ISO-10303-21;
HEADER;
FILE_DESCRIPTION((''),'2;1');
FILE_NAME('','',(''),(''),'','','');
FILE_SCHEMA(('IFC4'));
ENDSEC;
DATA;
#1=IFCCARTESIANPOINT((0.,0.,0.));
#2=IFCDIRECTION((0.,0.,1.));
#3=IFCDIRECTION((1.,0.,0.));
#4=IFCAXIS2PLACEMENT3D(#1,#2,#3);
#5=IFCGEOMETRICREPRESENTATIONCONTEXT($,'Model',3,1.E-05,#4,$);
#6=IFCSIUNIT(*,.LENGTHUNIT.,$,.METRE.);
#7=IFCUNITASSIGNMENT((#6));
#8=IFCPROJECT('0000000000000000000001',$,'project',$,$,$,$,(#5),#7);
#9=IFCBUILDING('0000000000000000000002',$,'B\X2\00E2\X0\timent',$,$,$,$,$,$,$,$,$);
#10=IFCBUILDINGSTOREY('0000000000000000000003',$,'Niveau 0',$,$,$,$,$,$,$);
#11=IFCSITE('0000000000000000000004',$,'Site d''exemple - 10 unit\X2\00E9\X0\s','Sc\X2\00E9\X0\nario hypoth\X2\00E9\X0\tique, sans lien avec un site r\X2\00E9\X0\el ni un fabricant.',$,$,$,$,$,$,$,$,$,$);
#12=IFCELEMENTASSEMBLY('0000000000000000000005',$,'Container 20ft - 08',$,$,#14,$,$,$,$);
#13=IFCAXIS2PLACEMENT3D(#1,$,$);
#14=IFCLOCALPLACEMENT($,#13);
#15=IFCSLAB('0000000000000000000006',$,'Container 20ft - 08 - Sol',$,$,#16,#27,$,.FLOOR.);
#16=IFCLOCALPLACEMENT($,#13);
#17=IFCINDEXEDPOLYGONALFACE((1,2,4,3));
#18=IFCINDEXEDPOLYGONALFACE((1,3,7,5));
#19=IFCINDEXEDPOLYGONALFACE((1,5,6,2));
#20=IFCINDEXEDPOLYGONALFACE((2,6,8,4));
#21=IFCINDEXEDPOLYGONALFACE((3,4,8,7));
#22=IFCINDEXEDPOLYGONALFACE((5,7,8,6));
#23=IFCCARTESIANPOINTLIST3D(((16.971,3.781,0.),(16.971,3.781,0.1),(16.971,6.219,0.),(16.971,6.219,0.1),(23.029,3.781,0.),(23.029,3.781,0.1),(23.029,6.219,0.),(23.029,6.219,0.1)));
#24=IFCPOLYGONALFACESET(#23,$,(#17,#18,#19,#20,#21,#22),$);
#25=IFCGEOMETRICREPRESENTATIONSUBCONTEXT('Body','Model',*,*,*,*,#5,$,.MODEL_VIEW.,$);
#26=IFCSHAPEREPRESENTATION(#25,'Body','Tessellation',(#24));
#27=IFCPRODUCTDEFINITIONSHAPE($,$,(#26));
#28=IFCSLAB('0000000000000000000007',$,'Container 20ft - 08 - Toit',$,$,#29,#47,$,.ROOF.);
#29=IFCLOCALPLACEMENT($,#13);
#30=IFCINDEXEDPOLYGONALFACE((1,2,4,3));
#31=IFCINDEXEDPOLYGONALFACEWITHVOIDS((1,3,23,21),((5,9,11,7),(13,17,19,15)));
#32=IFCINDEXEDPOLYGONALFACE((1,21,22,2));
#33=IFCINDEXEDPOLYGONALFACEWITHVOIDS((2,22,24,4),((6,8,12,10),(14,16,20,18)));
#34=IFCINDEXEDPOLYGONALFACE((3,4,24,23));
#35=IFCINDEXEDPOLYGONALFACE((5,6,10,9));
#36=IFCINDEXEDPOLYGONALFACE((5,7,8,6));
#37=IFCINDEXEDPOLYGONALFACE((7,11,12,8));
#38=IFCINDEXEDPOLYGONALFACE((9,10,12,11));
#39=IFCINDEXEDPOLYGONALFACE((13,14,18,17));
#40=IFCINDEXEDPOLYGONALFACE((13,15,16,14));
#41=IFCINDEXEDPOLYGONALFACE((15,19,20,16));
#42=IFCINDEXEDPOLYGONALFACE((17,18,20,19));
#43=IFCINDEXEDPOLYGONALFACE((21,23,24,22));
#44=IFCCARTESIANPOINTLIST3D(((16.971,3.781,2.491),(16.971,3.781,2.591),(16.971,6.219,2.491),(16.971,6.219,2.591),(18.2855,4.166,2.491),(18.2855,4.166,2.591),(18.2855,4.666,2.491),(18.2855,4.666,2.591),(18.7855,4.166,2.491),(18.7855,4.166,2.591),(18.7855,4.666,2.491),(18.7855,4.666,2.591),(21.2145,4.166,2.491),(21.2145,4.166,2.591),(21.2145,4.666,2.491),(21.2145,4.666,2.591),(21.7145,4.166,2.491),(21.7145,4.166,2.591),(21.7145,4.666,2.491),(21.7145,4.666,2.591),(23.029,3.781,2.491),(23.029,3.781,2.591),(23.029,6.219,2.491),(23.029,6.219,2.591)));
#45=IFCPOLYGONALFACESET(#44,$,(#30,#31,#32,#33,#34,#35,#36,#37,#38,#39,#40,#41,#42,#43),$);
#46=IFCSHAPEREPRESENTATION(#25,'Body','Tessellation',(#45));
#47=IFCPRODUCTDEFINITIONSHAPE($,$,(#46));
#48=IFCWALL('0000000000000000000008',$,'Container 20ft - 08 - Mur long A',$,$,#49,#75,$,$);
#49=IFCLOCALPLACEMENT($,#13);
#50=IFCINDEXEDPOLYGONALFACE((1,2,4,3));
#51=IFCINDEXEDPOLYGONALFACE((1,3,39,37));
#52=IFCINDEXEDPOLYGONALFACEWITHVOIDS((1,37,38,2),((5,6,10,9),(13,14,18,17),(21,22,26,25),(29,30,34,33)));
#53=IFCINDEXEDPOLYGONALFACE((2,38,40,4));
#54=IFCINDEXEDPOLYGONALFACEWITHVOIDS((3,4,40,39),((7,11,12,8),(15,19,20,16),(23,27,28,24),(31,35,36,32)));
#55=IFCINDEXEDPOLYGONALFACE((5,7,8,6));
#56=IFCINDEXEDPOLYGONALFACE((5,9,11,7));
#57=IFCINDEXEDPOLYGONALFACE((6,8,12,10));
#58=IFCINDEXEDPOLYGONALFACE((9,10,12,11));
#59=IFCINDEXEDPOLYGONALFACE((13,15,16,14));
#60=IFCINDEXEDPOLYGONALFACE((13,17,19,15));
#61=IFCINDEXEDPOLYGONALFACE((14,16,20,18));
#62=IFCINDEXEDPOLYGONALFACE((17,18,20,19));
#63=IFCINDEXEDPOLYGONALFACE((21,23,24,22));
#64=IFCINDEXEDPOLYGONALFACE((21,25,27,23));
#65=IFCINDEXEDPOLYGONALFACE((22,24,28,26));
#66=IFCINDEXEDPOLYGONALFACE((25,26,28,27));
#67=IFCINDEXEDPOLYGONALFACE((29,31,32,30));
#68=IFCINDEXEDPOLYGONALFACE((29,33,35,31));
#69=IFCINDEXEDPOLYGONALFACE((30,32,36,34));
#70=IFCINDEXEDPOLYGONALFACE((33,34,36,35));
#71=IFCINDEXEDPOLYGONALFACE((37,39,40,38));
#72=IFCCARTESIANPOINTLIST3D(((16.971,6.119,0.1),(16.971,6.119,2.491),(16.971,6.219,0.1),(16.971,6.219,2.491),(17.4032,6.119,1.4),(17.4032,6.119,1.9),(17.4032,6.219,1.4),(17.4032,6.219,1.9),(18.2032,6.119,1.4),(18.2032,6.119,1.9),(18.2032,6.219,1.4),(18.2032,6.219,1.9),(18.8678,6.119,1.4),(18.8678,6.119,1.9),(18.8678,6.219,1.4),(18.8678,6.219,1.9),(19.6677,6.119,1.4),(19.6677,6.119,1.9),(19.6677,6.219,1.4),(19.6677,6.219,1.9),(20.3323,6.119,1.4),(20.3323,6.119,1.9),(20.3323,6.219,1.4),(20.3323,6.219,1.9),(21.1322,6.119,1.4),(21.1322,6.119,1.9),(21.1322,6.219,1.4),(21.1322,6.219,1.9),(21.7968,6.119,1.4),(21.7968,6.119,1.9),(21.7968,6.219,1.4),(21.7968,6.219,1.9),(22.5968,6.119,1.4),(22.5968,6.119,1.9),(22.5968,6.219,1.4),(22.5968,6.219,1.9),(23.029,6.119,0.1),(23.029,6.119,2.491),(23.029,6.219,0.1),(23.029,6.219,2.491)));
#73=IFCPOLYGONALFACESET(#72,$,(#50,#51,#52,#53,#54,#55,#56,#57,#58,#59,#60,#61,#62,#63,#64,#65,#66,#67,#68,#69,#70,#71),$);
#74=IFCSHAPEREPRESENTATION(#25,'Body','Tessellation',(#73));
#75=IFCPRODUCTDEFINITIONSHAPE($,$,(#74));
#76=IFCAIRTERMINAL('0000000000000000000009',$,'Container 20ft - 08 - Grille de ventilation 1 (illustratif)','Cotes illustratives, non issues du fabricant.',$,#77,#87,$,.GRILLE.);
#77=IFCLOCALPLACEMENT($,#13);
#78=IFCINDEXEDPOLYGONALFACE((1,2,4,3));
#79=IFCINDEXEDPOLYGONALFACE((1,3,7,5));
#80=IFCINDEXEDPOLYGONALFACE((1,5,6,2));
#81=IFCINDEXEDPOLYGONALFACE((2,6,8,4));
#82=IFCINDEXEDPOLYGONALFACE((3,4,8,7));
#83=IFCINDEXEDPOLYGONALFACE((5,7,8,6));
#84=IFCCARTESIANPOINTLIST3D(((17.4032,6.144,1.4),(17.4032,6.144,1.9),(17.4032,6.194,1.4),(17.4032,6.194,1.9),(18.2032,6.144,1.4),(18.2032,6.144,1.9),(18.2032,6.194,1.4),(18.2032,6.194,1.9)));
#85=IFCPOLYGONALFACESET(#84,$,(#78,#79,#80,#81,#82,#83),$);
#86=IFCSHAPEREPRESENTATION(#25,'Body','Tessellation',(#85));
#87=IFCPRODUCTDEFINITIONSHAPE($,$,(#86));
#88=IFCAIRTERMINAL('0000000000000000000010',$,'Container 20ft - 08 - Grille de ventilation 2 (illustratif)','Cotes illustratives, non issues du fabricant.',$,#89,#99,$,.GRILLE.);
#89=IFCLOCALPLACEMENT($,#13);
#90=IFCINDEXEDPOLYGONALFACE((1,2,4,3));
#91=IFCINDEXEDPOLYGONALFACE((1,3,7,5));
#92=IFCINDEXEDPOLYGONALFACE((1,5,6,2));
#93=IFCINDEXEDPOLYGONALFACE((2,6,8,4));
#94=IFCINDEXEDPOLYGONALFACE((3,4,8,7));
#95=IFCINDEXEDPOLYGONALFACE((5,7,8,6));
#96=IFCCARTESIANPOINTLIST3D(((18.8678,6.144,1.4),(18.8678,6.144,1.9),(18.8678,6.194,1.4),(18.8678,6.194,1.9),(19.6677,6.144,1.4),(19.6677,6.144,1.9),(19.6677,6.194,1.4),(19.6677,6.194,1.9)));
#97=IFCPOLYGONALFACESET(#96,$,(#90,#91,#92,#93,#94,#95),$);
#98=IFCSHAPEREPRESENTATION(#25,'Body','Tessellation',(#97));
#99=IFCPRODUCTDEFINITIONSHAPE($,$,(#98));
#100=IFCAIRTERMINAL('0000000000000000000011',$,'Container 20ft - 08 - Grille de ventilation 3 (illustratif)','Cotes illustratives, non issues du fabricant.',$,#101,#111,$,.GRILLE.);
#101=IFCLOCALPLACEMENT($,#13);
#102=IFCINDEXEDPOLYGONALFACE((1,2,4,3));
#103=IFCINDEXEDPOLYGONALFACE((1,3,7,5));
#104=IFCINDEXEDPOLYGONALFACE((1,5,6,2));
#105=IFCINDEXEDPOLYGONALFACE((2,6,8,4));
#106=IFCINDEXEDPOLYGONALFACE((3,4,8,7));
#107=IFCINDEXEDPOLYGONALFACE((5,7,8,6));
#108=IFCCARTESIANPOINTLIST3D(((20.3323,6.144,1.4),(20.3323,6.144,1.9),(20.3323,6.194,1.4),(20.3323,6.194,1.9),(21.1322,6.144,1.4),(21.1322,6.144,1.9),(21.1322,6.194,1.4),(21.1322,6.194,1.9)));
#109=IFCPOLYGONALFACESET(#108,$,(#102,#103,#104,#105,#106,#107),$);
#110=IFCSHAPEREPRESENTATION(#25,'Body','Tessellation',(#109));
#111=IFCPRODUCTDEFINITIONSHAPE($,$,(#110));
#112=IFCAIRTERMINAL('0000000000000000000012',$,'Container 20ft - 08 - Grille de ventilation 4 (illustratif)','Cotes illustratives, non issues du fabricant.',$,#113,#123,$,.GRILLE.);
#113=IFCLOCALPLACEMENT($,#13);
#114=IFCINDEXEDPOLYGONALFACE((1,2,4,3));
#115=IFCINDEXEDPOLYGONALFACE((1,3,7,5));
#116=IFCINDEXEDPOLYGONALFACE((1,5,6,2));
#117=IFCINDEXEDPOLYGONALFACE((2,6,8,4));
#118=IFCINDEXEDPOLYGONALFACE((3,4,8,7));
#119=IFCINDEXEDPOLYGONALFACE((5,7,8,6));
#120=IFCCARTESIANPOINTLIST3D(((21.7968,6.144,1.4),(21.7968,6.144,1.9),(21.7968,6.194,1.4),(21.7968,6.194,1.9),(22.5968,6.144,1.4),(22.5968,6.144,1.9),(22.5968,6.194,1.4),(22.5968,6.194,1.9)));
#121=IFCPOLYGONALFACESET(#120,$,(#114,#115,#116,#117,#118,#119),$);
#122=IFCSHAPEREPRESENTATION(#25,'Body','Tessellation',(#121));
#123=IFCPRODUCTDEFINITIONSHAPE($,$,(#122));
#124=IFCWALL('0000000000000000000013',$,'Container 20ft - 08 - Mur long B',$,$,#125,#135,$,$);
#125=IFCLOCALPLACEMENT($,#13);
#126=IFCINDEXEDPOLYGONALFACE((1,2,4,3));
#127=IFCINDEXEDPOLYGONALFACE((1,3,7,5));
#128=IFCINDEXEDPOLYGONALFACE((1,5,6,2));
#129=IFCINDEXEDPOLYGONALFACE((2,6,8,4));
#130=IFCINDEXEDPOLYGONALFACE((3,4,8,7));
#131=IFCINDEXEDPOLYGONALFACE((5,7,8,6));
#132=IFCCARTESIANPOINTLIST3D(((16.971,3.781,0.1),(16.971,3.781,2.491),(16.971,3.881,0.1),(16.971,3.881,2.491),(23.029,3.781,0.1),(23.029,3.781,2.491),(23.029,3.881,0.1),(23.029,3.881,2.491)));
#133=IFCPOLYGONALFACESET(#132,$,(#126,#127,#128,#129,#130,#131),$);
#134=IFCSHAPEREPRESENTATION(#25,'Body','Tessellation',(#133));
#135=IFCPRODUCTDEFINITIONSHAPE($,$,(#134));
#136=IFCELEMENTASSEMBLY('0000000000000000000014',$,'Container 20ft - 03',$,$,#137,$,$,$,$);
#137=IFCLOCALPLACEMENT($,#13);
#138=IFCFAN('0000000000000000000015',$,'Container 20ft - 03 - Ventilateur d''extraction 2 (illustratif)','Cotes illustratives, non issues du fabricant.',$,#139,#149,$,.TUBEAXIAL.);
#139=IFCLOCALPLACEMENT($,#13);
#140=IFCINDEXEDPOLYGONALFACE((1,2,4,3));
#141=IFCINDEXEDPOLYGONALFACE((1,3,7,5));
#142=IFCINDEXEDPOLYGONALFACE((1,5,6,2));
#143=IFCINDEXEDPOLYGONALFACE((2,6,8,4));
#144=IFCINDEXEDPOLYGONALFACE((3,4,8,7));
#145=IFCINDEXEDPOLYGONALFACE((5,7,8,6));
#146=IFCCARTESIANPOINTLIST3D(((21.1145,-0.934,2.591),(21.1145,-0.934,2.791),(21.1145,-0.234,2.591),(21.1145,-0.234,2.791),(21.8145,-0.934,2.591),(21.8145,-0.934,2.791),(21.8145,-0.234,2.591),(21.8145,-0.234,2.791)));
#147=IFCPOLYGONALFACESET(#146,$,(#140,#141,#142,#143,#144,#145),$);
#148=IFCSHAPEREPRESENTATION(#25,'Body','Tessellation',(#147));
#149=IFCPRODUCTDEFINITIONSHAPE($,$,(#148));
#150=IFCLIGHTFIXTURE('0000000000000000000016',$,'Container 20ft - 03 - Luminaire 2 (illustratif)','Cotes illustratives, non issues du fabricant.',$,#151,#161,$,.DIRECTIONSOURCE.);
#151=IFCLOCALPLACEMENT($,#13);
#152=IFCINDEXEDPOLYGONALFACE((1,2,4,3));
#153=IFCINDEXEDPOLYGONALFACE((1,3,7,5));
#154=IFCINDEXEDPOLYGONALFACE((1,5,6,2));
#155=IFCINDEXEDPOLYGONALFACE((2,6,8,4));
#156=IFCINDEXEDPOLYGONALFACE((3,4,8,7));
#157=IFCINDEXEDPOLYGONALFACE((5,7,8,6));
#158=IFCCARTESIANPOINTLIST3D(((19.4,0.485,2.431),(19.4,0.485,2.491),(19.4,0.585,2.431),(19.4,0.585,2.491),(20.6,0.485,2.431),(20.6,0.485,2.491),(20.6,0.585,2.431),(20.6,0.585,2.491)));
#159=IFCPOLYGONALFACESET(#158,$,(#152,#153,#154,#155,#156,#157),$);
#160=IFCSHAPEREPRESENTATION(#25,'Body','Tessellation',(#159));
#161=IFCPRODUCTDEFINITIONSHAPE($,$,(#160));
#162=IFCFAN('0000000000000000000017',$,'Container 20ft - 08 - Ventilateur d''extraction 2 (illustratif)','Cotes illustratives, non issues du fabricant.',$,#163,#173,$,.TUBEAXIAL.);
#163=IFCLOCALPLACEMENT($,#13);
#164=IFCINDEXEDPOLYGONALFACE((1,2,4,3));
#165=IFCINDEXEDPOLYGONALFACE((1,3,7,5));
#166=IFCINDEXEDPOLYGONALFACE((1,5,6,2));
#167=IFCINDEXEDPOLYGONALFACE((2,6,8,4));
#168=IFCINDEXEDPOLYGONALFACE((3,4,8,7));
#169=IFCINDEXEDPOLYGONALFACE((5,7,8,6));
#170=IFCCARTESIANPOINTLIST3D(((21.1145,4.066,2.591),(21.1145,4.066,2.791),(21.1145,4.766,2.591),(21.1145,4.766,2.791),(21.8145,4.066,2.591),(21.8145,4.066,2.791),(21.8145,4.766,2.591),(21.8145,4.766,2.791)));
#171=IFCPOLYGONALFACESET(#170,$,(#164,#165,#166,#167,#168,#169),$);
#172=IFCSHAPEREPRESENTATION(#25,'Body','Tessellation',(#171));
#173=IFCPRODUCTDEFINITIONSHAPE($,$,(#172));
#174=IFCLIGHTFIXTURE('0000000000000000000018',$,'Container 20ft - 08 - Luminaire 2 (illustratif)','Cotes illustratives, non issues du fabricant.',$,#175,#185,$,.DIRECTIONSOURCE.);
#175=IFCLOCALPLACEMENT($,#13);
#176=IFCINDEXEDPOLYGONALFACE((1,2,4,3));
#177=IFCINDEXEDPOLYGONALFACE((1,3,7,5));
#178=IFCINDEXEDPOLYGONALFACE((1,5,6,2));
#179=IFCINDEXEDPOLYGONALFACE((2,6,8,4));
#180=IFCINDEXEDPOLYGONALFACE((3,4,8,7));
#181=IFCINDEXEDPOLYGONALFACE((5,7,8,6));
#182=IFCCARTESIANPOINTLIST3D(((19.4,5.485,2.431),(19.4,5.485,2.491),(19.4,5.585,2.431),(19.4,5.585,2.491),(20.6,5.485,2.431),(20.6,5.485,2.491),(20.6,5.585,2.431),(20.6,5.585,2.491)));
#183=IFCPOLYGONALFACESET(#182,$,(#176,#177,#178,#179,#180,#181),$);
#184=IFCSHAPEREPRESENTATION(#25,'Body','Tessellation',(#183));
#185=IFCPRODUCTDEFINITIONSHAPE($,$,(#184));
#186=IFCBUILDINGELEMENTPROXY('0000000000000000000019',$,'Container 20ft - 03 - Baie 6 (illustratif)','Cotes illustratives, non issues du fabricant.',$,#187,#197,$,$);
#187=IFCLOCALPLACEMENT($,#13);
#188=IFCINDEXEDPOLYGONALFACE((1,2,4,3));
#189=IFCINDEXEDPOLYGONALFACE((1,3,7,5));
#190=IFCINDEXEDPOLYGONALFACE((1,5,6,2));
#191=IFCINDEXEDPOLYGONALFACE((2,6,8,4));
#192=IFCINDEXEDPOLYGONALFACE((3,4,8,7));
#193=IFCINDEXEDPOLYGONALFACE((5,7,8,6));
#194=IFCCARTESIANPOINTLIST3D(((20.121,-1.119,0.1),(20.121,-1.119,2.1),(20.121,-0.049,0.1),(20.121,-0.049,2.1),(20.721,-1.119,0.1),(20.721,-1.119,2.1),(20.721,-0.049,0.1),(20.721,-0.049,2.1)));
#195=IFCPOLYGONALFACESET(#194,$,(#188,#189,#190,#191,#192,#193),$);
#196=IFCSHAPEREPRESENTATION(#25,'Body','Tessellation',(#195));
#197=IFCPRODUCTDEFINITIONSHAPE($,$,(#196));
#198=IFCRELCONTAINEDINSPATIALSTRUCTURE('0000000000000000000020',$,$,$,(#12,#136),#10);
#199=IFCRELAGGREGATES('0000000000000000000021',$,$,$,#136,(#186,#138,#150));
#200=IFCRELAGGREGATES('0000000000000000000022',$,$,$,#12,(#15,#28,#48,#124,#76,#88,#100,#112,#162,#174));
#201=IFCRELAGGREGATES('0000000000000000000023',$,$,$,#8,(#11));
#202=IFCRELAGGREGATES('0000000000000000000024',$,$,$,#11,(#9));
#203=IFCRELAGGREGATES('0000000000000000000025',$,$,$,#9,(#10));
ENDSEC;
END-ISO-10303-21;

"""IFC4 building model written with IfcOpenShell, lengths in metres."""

from ifc_helpers import new_model, si_unit, frame, origin_with_axes, place, context, subcontext, project, spatial, rectangle, extrude, element, fill, aggregate, save


model = new_model("IFC4")

# Units and contexts
model_context = context("Model", 3, precision=1e-05, world=origin_with_axes())
body_context = subcontext(model_context, "Body", "Model", "MODEL_VIEW")
ifc_project = project(units=[si_unit("LENGTHUNIT", "METRE")], contexts=[model_context])

# Site, building, storey
site = spatial("IfcSite", under=ifc_project, Name="Site d'exemple - 10 unités", Description="Scénario hypothétique, sans lien avec un site réel ni un fabricant.")
building = spatial("IfcBuilding", under=site, Name="Bâtiment")
storey = spatial("IfcBuildingStorey", under=building, Name="Niveau 0")

# Element assembly, slabs, openings, walls, air terminals
assembly_1 = element("IfcElementAssembly", 1, inside=storey, Name="Container 20ft - 08")
slab_1_placement = place(None, frame((20.0, 5.0, 0.0), z_axis=(0.0, 0.0, 1.0), x_axis=(1.0, 0.0, 0.0)))
slab_1 = element("IfcSlab", 2, at=slab_1_placement, Name="Container 20ft - 08 - Sol", PredefinedType="FLOOR", context=body_context, shape_type="SweptSolid", body=[
    extrude(rectangle(XDim=6.058, YDim=2.438), origin_with_axes(), (0.0, 0.0, 1.0), 0.1),
])
slab_2_placement = place(None, frame((20.0, 5.0, 2.491), z_axis=(0.0, 0.0, 1.0), x_axis=(1.0, 0.0, 0.0)))
slab_2 = element("IfcSlab", 3, at=slab_2_placement, Name="Container 20ft - 08 - Toit", PredefinedType="ROOF", context=body_context, shape_type="SweptSolid", body=[
    extrude(rectangle(XDim=6.058, YDim=2.438), origin_with_axes(), (0.0, 0.0, 1.0), 0.1),
])
opening_1_placement = place(None, frame((18.5355, 4.416, 2.441), z_axis=(0.0, 0.0, 1.0), x_axis=(1.0, 0.0, 0.0)))
element("IfcOpeningElement", 4, at=opening_1_placement, cuts=slab_2, PredefinedType="OPENING", context=body_context, shape_type="SweptSolid", body=[
    extrude(rectangle(XDim=0.5, YDim=0.5), origin_with_axes(), (0.0, 0.0, 1.0), 0.2),
])
opening_2_placement = place(None, frame((21.4645, 4.416, 2.441), z_axis=(0.0, 0.0, 1.0), x_axis=(1.0, 0.0, 0.0)))
element("IfcOpeningElement", 5, at=opening_2_placement, cuts=slab_2, PredefinedType="OPENING", context=body_context, shape_type="SweptSolid", body=[
    extrude(rectangle(XDim=0.5, YDim=0.5), origin_with_axes(), (0.0, 0.0, 1.0), 0.2),
])
wall_1_placement = place(None, frame((20.0, 6.169, 0.1), z_axis=(0.0, 0.0, 1.0), x_axis=(1.0, 0.0, 0.0)))
wall_1 = element("IfcWall", 6, at=wall_1_placement, Name="Container 20ft - 08 - Mur long A", context=body_context, shape_type="SweptSolid", body=[
    extrude(rectangle(XDim=6.058, YDim=0.1), origin_with_axes(), (0.0, 0.0, 1.0), 2.391),
])
opening_3_placement = place(None, frame((17.8032, 6.169, 1.4), z_axis=(0.0, 0.0, 1.0), x_axis=(1.0, 0.0, 0.0)))
opening_3 = element("IfcOpeningElement", 7, at=opening_3_placement, cuts=wall_1, PredefinedType="OPENING", context=body_context, shape_type="SweptSolid", body=[
    extrude(rectangle(XDim=0.8, YDim=0.2), origin_with_axes(), (0.0, 0.0, 1.0), 0.5),
])
opening_4_placement = place(None, frame((19.2677, 6.169, 1.4), z_axis=(0.0, 0.0, 1.0), x_axis=(1.0, 0.0, 0.0)))
opening_4 = element("IfcOpeningElement", 8, at=opening_4_placement, cuts=wall_1, PredefinedType="OPENING", context=body_context, shape_type="SweptSolid", body=[
    extrude(rectangle(XDim=0.8, YDim=0.2), origin_with_axes(), (0.0, 0.0, 1.0), 0.5),
])
opening_5_placement = place(None, frame((20.7323, 6.169, 1.4), z_axis=(0.0, 0.0, 1.0), x_axis=(1.0, 0.0, 0.0)))
opening_5 = element("IfcOpeningElement", 9, at=opening_5_placement, cuts=wall_1, PredefinedType="OPENING", context=body_context, shape_type="SweptSolid", body=[
    extrude(rectangle(XDim=0.8, YDim=0.2), origin_with_axes(), (0.0, 0.0, 1.0), 0.5),
])
opening_6_placement = place(None, frame((22.1968, 6.169, 1.4), z_axis=(0.0, 0.0, 1.0), x_axis=(1.0, 0.0, 0.0)))
opening_6 = element("IfcOpeningElement", 10, at=opening_6_placement, cuts=wall_1, PredefinedType="OPENING", context=body_context, shape_type="SweptSolid", body=[
    extrude(rectangle(XDim=0.8, YDim=0.2), origin_with_axes(), (0.0, 0.0, 1.0), 0.5),
])
air_terminal_1_placement = place(None, frame((17.8032, 6.169, 1.4), z_axis=(0.0, 0.0, 1.0), x_axis=(1.0, 0.0, 0.0)))
air_terminal_1 = element("IfcAirTerminal", 11, at=air_terminal_1_placement, Name="Container 20ft - 08 - Grille de ventilation 1 (illustratif)", Description="Cotes illustratives, non issues du fabricant.", PredefinedType="GRILLE", context=body_context, shape_type="SweptSolid", body=[
    extrude(rectangle(XDim=0.8, YDim=0.05), origin_with_axes(), (0.0, 0.0, 1.0), 0.5),
])
fill(opening_3, air_terminal_1)
air_terminal_2_placement = place(None, frame((19.2677, 6.169, 1.4), z_axis=(0.0, 0.0, 1.0), x_axis=(1.0, 0.0, 0.0)))
air_terminal_2 = element("IfcAirTerminal", 12, at=air_terminal_2_placement, Name="Container 20ft - 08 - Grille de ventilation 2 (illustratif)", Description="Cotes illustratives, non issues du fabricant.", PredefinedType="GRILLE", context=body_context, shape_type="SweptSolid", body=[
    extrude(rectangle(XDim=0.8, YDim=0.05), origin_with_axes(), (0.0, 0.0, 1.0), 0.5),
])
fill(opening_4, air_terminal_2)
air_terminal_3_placement = place(None, frame((20.7323, 6.169, 1.4), z_axis=(0.0, 0.0, 1.0), x_axis=(1.0, 0.0, 0.0)))
air_terminal_3 = element("IfcAirTerminal", 13, at=air_terminal_3_placement, Name="Container 20ft - 08 - Grille de ventilation 3 (illustratif)", Description="Cotes illustratives, non issues du fabricant.", PredefinedType="GRILLE", context=body_context, shape_type="SweptSolid", body=[
    extrude(rectangle(XDim=0.8, YDim=0.05), origin_with_axes(), (0.0, 0.0, 1.0), 0.5),
])
fill(opening_5, air_terminal_3)
air_terminal_4_placement = place(None, frame((22.1968, 6.169, 1.4), z_axis=(0.0, 0.0, 1.0), x_axis=(1.0, 0.0, 0.0)))
air_terminal_4 = element("IfcAirTerminal", 14, at=air_terminal_4_placement, Name="Container 20ft - 08 - Grille de ventilation 4 (illustratif)", Description="Cotes illustratives, non issues du fabricant.", PredefinedType="GRILLE", context=body_context, shape_type="SweptSolid", body=[
    extrude(rectangle(XDim=0.8, YDim=0.05), origin_with_axes(), (0.0, 0.0, 1.0), 0.5),
])
fill(opening_6, air_terminal_4)
wall_2_placement = place(None, frame((20.0, 3.831, 0.1), z_axis=(0.0, 0.0, 1.0), x_axis=(1.0, 0.0, 0.0)))
wall_2 = element("IfcWall", 15, at=wall_2_placement, Name="Container 20ft - 08 - Mur long B", context=body_context, shape_type="SweptSolid", body=[
    extrude(rectangle(XDim=6.058, YDim=0.1), origin_with_axes(), (0.0, 0.0, 1.0), 2.391),
])

# Element assembly, fan, light fixture
assembly_2 = element("IfcElementAssembly", 16, inside=storey, Name="Container 20ft - 03")
fan_1_placement = place(None, frame((21.4645, -0.584, 2.591), z_axis=(0.0, 0.0, 1.0), x_axis=(1.0, 0.0, 0.0)))
fan_1 = element("IfcFan", 17, at=fan_1_placement, Name="Container 20ft - 03 - Ventilateur d'extraction 2 (illustratif)", Description="Cotes illustratives, non issues du fabricant.", PredefinedType="TUBEAXIAL", context=body_context, shape_type="SweptSolid", body=[
    extrude(rectangle(XDim=0.7, YDim=0.7), origin_with_axes(), (0.0, 0.0, 1.0), 0.2),
])
light_fixture_1_placement = place(None, frame((20.0, 0.535, 2.431), z_axis=(0.0, 0.0, 1.0), x_axis=(1.0, 0.0, 0.0)))
light_fixture_1 = element("IfcLightFixture", 18, at=light_fixture_1_placement, Name="Container 20ft - 03 - Luminaire 2 (illustratif)", Description="Cotes illustratives, non issues du fabricant.", PredefinedType="DIRECTIONSOURCE", context=body_context, shape_type="SweptSolid", body=[
    extrude(rectangle(XDim=1.2, YDim=0.1), origin_with_axes(), (0.0, 0.0, 1.0), 0.06),
])

# Fan
fan_2_placement = place(None, frame((21.4645, 4.416, 2.591), z_axis=(0.0, 0.0, 1.0), x_axis=(1.0, 0.0, 0.0)))
fan_2 = element("IfcFan", 19, at=fan_2_placement, Name="Container 20ft - 08 - Ventilateur d'extraction 2 (illustratif)", Description="Cotes illustratives, non issues du fabricant.", PredefinedType="TUBEAXIAL", context=body_context, shape_type="SweptSolid", body=[
    extrude(rectangle(XDim=0.7, YDim=0.7), origin_with_axes(), (0.0, 0.0, 1.0), 0.2),
])

# Light fixture
light_fixture_2_placement = place(None, frame((20.0, 5.535, 2.431), z_axis=(0.0, 0.0, 1.0), x_axis=(1.0, 0.0, 0.0)))
light_fixture_2 = element("IfcLightFixture", 20, at=light_fixture_2_placement, Name="Container 20ft - 08 - Luminaire 2 (illustratif)", Description="Cotes illustratives, non issues du fabricant.", PredefinedType="DIRECTIONSOURCE", context=body_context, shape_type="SweptSolid", body=[
    extrude(rectangle(XDim=1.2, YDim=0.1), origin_with_axes(), (0.0, 0.0, 1.0), 0.06),
])

# Building element proxy
proxy_1_placement = place(None, frame((20.421, -0.584, 0.1), z_axis=(0.0, 0.0, 1.0), x_axis=(1.0, 0.0, 0.0)))
proxy_1 = element("IfcBuildingElementProxy", 21, at=proxy_1_placement, Name="Container 20ft - 03 - Baie 6 (illustratif)", Description="Cotes illustratives, non issues du fabricant.", context=body_context, shape_type="SweptSolid", body=[
    extrude(rectangle(XDim=0.6, YDim=1.07), origin_with_axes(), (0.0, 0.0, 1.0), 2.0),
])
aggregate(assembly_2, [proxy_1, fan_1, light_fixture_1])
aggregate(assembly_1, [slab_1, slab_2, wall_1, wall_2, air_terminal_1, air_terminal_2, air_terminal_3, air_terminal_4, fan_2, light_fixture_2])

save(model, "model.ifc")
